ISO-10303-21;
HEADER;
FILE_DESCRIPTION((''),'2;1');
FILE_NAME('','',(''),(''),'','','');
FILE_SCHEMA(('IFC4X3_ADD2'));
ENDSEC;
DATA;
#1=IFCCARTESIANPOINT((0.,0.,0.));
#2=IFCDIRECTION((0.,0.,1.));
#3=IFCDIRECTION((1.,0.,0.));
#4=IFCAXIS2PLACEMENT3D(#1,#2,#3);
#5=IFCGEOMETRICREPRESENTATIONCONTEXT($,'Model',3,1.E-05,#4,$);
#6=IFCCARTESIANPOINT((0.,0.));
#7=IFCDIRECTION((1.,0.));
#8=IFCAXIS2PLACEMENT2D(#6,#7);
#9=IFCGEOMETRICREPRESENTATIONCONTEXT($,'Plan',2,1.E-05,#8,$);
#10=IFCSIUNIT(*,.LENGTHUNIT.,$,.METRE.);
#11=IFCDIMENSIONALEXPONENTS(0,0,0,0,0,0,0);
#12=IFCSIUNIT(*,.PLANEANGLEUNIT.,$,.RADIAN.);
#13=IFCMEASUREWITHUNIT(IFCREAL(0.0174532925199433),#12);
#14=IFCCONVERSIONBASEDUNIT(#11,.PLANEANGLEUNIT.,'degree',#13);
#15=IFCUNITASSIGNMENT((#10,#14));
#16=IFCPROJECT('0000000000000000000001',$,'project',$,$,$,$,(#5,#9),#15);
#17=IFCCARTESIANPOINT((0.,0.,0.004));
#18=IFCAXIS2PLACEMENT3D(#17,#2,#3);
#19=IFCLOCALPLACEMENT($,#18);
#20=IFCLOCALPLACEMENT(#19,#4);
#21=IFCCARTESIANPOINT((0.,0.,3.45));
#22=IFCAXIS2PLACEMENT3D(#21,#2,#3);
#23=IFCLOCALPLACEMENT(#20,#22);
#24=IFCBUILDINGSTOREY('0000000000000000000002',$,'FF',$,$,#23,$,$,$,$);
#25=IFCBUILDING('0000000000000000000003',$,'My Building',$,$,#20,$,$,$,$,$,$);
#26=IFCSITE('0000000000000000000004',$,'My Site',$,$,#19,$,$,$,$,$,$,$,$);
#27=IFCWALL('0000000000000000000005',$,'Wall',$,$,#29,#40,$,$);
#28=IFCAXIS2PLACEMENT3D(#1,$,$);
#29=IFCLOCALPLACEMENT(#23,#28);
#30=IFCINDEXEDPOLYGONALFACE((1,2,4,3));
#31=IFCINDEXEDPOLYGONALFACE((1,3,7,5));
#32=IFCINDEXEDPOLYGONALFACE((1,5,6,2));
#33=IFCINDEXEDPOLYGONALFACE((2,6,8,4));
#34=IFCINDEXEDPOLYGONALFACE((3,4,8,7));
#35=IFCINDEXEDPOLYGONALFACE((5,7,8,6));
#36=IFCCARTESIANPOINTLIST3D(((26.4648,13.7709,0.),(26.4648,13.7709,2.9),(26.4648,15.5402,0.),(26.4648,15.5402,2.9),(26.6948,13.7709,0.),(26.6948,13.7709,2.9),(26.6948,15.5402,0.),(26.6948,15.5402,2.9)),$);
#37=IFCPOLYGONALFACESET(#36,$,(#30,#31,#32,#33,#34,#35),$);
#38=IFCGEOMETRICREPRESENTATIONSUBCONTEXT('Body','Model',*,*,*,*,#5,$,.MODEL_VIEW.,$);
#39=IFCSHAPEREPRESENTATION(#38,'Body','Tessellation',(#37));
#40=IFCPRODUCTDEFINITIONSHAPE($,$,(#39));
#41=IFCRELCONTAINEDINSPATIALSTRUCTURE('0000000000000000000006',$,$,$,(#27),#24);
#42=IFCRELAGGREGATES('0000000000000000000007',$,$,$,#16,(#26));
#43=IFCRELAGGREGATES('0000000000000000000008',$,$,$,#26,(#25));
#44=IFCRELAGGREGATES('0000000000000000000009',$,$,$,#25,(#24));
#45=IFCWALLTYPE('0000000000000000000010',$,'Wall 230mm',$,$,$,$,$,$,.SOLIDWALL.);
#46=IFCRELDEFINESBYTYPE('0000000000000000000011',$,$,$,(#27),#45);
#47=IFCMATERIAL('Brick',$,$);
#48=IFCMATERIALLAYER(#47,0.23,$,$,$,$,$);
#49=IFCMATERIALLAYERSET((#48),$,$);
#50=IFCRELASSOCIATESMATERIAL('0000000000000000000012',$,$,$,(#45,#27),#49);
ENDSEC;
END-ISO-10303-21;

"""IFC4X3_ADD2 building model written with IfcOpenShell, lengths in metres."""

from ifc_helpers import new_model, entity, si_unit, converted_unit, frame, origin_with_axes, origin_2d_with_axis, place, context, subcontext, project, spatial, indexed_curve, outline, extrude, material, layer, layer_set, layer_usage, type_object, element, save


model = new_model("IFC4X3_ADD2")

# Units and contexts
model_context = context("Model", 3, precision=1e-05, world=origin_with_axes())
plan_context = context("Plan", 2, precision=1e-05, world=origin_2d_with_axis())
body_context = subcontext(model_context, "Body", "Model", "MODEL_VIEW")
ifc_project = project(units=[si_unit("LENGTHUNIT", "METRE"), converted_unit("PLANEANGLEUNIT", "degree", entity("IfcReal", 0.0174532925199433), si_unit("PLANEANGLEUNIT", "RADIAN"), dimensions=[0, 0, 0, 0, 0, 0, 0])], contexts=[model_context, plan_context])

# Site, building, storey
site_placement = place(None, frame((0.0, 0.0, 0.004), z_axis=(0.0, 0.0, 1.0), x_axis=(1.0, 0.0, 0.0)))
site = spatial("IfcSite", under=ifc_project, at=site_placement, Name="My Site")
building_placement = place(site_placement, origin_with_axes())
building = spatial("IfcBuilding", under=site, at=building_placement, Name="My Building")
storey_placement = place(building_placement, frame((0.0, 0.0, 3.45), z_axis=(0.0, 0.0, 1.0), x_axis=(1.0, 0.0, 0.0)))
storey = spatial("IfcBuildingStorey", under=building, at=storey_placement, Name="FF")

# Wall
ifc_material = material(Name="Brick")
ifc_layer_1 = layer(ifc_material, 0.23)
ifc_layer_set_1 = layer_set([ifc_layer_1])
wall_type_1 = type_object("IfcWallType", Name="Wall 230mm", PredefinedType="SOLIDWALL", material=ifc_layer_set_1)
ifc_layer_usage_1 = layer_usage(ifc_layer_set_1, "AXIS2", "POSITIVE", 0.0)
wall_1_placement = place(storey_placement, frame((26.6948, 13.7709, 0.0), z_axis=(0.0, 0.0, 1.0), x_axis=(0.000001, 1.0, 0.0)))
element("IfcWall", 1, at=wall_1_placement, inside=storey, type_object=wall_type_1, material=ifc_layer_usage_1, Name="Wall", context=body_context, shape_type="SweptSolid", body=[
    extrude(outline(indexed_curve([(0.0, 0.0), (0.0, 0.23), (1.7693, 0.23), (1.7693, 0.0), (0.0, 0.0)], self_intersect=False)), origin_with_axes(), (0.0, 0.0, 1.0), 2.9),
])

save(model, "model.ifc")
